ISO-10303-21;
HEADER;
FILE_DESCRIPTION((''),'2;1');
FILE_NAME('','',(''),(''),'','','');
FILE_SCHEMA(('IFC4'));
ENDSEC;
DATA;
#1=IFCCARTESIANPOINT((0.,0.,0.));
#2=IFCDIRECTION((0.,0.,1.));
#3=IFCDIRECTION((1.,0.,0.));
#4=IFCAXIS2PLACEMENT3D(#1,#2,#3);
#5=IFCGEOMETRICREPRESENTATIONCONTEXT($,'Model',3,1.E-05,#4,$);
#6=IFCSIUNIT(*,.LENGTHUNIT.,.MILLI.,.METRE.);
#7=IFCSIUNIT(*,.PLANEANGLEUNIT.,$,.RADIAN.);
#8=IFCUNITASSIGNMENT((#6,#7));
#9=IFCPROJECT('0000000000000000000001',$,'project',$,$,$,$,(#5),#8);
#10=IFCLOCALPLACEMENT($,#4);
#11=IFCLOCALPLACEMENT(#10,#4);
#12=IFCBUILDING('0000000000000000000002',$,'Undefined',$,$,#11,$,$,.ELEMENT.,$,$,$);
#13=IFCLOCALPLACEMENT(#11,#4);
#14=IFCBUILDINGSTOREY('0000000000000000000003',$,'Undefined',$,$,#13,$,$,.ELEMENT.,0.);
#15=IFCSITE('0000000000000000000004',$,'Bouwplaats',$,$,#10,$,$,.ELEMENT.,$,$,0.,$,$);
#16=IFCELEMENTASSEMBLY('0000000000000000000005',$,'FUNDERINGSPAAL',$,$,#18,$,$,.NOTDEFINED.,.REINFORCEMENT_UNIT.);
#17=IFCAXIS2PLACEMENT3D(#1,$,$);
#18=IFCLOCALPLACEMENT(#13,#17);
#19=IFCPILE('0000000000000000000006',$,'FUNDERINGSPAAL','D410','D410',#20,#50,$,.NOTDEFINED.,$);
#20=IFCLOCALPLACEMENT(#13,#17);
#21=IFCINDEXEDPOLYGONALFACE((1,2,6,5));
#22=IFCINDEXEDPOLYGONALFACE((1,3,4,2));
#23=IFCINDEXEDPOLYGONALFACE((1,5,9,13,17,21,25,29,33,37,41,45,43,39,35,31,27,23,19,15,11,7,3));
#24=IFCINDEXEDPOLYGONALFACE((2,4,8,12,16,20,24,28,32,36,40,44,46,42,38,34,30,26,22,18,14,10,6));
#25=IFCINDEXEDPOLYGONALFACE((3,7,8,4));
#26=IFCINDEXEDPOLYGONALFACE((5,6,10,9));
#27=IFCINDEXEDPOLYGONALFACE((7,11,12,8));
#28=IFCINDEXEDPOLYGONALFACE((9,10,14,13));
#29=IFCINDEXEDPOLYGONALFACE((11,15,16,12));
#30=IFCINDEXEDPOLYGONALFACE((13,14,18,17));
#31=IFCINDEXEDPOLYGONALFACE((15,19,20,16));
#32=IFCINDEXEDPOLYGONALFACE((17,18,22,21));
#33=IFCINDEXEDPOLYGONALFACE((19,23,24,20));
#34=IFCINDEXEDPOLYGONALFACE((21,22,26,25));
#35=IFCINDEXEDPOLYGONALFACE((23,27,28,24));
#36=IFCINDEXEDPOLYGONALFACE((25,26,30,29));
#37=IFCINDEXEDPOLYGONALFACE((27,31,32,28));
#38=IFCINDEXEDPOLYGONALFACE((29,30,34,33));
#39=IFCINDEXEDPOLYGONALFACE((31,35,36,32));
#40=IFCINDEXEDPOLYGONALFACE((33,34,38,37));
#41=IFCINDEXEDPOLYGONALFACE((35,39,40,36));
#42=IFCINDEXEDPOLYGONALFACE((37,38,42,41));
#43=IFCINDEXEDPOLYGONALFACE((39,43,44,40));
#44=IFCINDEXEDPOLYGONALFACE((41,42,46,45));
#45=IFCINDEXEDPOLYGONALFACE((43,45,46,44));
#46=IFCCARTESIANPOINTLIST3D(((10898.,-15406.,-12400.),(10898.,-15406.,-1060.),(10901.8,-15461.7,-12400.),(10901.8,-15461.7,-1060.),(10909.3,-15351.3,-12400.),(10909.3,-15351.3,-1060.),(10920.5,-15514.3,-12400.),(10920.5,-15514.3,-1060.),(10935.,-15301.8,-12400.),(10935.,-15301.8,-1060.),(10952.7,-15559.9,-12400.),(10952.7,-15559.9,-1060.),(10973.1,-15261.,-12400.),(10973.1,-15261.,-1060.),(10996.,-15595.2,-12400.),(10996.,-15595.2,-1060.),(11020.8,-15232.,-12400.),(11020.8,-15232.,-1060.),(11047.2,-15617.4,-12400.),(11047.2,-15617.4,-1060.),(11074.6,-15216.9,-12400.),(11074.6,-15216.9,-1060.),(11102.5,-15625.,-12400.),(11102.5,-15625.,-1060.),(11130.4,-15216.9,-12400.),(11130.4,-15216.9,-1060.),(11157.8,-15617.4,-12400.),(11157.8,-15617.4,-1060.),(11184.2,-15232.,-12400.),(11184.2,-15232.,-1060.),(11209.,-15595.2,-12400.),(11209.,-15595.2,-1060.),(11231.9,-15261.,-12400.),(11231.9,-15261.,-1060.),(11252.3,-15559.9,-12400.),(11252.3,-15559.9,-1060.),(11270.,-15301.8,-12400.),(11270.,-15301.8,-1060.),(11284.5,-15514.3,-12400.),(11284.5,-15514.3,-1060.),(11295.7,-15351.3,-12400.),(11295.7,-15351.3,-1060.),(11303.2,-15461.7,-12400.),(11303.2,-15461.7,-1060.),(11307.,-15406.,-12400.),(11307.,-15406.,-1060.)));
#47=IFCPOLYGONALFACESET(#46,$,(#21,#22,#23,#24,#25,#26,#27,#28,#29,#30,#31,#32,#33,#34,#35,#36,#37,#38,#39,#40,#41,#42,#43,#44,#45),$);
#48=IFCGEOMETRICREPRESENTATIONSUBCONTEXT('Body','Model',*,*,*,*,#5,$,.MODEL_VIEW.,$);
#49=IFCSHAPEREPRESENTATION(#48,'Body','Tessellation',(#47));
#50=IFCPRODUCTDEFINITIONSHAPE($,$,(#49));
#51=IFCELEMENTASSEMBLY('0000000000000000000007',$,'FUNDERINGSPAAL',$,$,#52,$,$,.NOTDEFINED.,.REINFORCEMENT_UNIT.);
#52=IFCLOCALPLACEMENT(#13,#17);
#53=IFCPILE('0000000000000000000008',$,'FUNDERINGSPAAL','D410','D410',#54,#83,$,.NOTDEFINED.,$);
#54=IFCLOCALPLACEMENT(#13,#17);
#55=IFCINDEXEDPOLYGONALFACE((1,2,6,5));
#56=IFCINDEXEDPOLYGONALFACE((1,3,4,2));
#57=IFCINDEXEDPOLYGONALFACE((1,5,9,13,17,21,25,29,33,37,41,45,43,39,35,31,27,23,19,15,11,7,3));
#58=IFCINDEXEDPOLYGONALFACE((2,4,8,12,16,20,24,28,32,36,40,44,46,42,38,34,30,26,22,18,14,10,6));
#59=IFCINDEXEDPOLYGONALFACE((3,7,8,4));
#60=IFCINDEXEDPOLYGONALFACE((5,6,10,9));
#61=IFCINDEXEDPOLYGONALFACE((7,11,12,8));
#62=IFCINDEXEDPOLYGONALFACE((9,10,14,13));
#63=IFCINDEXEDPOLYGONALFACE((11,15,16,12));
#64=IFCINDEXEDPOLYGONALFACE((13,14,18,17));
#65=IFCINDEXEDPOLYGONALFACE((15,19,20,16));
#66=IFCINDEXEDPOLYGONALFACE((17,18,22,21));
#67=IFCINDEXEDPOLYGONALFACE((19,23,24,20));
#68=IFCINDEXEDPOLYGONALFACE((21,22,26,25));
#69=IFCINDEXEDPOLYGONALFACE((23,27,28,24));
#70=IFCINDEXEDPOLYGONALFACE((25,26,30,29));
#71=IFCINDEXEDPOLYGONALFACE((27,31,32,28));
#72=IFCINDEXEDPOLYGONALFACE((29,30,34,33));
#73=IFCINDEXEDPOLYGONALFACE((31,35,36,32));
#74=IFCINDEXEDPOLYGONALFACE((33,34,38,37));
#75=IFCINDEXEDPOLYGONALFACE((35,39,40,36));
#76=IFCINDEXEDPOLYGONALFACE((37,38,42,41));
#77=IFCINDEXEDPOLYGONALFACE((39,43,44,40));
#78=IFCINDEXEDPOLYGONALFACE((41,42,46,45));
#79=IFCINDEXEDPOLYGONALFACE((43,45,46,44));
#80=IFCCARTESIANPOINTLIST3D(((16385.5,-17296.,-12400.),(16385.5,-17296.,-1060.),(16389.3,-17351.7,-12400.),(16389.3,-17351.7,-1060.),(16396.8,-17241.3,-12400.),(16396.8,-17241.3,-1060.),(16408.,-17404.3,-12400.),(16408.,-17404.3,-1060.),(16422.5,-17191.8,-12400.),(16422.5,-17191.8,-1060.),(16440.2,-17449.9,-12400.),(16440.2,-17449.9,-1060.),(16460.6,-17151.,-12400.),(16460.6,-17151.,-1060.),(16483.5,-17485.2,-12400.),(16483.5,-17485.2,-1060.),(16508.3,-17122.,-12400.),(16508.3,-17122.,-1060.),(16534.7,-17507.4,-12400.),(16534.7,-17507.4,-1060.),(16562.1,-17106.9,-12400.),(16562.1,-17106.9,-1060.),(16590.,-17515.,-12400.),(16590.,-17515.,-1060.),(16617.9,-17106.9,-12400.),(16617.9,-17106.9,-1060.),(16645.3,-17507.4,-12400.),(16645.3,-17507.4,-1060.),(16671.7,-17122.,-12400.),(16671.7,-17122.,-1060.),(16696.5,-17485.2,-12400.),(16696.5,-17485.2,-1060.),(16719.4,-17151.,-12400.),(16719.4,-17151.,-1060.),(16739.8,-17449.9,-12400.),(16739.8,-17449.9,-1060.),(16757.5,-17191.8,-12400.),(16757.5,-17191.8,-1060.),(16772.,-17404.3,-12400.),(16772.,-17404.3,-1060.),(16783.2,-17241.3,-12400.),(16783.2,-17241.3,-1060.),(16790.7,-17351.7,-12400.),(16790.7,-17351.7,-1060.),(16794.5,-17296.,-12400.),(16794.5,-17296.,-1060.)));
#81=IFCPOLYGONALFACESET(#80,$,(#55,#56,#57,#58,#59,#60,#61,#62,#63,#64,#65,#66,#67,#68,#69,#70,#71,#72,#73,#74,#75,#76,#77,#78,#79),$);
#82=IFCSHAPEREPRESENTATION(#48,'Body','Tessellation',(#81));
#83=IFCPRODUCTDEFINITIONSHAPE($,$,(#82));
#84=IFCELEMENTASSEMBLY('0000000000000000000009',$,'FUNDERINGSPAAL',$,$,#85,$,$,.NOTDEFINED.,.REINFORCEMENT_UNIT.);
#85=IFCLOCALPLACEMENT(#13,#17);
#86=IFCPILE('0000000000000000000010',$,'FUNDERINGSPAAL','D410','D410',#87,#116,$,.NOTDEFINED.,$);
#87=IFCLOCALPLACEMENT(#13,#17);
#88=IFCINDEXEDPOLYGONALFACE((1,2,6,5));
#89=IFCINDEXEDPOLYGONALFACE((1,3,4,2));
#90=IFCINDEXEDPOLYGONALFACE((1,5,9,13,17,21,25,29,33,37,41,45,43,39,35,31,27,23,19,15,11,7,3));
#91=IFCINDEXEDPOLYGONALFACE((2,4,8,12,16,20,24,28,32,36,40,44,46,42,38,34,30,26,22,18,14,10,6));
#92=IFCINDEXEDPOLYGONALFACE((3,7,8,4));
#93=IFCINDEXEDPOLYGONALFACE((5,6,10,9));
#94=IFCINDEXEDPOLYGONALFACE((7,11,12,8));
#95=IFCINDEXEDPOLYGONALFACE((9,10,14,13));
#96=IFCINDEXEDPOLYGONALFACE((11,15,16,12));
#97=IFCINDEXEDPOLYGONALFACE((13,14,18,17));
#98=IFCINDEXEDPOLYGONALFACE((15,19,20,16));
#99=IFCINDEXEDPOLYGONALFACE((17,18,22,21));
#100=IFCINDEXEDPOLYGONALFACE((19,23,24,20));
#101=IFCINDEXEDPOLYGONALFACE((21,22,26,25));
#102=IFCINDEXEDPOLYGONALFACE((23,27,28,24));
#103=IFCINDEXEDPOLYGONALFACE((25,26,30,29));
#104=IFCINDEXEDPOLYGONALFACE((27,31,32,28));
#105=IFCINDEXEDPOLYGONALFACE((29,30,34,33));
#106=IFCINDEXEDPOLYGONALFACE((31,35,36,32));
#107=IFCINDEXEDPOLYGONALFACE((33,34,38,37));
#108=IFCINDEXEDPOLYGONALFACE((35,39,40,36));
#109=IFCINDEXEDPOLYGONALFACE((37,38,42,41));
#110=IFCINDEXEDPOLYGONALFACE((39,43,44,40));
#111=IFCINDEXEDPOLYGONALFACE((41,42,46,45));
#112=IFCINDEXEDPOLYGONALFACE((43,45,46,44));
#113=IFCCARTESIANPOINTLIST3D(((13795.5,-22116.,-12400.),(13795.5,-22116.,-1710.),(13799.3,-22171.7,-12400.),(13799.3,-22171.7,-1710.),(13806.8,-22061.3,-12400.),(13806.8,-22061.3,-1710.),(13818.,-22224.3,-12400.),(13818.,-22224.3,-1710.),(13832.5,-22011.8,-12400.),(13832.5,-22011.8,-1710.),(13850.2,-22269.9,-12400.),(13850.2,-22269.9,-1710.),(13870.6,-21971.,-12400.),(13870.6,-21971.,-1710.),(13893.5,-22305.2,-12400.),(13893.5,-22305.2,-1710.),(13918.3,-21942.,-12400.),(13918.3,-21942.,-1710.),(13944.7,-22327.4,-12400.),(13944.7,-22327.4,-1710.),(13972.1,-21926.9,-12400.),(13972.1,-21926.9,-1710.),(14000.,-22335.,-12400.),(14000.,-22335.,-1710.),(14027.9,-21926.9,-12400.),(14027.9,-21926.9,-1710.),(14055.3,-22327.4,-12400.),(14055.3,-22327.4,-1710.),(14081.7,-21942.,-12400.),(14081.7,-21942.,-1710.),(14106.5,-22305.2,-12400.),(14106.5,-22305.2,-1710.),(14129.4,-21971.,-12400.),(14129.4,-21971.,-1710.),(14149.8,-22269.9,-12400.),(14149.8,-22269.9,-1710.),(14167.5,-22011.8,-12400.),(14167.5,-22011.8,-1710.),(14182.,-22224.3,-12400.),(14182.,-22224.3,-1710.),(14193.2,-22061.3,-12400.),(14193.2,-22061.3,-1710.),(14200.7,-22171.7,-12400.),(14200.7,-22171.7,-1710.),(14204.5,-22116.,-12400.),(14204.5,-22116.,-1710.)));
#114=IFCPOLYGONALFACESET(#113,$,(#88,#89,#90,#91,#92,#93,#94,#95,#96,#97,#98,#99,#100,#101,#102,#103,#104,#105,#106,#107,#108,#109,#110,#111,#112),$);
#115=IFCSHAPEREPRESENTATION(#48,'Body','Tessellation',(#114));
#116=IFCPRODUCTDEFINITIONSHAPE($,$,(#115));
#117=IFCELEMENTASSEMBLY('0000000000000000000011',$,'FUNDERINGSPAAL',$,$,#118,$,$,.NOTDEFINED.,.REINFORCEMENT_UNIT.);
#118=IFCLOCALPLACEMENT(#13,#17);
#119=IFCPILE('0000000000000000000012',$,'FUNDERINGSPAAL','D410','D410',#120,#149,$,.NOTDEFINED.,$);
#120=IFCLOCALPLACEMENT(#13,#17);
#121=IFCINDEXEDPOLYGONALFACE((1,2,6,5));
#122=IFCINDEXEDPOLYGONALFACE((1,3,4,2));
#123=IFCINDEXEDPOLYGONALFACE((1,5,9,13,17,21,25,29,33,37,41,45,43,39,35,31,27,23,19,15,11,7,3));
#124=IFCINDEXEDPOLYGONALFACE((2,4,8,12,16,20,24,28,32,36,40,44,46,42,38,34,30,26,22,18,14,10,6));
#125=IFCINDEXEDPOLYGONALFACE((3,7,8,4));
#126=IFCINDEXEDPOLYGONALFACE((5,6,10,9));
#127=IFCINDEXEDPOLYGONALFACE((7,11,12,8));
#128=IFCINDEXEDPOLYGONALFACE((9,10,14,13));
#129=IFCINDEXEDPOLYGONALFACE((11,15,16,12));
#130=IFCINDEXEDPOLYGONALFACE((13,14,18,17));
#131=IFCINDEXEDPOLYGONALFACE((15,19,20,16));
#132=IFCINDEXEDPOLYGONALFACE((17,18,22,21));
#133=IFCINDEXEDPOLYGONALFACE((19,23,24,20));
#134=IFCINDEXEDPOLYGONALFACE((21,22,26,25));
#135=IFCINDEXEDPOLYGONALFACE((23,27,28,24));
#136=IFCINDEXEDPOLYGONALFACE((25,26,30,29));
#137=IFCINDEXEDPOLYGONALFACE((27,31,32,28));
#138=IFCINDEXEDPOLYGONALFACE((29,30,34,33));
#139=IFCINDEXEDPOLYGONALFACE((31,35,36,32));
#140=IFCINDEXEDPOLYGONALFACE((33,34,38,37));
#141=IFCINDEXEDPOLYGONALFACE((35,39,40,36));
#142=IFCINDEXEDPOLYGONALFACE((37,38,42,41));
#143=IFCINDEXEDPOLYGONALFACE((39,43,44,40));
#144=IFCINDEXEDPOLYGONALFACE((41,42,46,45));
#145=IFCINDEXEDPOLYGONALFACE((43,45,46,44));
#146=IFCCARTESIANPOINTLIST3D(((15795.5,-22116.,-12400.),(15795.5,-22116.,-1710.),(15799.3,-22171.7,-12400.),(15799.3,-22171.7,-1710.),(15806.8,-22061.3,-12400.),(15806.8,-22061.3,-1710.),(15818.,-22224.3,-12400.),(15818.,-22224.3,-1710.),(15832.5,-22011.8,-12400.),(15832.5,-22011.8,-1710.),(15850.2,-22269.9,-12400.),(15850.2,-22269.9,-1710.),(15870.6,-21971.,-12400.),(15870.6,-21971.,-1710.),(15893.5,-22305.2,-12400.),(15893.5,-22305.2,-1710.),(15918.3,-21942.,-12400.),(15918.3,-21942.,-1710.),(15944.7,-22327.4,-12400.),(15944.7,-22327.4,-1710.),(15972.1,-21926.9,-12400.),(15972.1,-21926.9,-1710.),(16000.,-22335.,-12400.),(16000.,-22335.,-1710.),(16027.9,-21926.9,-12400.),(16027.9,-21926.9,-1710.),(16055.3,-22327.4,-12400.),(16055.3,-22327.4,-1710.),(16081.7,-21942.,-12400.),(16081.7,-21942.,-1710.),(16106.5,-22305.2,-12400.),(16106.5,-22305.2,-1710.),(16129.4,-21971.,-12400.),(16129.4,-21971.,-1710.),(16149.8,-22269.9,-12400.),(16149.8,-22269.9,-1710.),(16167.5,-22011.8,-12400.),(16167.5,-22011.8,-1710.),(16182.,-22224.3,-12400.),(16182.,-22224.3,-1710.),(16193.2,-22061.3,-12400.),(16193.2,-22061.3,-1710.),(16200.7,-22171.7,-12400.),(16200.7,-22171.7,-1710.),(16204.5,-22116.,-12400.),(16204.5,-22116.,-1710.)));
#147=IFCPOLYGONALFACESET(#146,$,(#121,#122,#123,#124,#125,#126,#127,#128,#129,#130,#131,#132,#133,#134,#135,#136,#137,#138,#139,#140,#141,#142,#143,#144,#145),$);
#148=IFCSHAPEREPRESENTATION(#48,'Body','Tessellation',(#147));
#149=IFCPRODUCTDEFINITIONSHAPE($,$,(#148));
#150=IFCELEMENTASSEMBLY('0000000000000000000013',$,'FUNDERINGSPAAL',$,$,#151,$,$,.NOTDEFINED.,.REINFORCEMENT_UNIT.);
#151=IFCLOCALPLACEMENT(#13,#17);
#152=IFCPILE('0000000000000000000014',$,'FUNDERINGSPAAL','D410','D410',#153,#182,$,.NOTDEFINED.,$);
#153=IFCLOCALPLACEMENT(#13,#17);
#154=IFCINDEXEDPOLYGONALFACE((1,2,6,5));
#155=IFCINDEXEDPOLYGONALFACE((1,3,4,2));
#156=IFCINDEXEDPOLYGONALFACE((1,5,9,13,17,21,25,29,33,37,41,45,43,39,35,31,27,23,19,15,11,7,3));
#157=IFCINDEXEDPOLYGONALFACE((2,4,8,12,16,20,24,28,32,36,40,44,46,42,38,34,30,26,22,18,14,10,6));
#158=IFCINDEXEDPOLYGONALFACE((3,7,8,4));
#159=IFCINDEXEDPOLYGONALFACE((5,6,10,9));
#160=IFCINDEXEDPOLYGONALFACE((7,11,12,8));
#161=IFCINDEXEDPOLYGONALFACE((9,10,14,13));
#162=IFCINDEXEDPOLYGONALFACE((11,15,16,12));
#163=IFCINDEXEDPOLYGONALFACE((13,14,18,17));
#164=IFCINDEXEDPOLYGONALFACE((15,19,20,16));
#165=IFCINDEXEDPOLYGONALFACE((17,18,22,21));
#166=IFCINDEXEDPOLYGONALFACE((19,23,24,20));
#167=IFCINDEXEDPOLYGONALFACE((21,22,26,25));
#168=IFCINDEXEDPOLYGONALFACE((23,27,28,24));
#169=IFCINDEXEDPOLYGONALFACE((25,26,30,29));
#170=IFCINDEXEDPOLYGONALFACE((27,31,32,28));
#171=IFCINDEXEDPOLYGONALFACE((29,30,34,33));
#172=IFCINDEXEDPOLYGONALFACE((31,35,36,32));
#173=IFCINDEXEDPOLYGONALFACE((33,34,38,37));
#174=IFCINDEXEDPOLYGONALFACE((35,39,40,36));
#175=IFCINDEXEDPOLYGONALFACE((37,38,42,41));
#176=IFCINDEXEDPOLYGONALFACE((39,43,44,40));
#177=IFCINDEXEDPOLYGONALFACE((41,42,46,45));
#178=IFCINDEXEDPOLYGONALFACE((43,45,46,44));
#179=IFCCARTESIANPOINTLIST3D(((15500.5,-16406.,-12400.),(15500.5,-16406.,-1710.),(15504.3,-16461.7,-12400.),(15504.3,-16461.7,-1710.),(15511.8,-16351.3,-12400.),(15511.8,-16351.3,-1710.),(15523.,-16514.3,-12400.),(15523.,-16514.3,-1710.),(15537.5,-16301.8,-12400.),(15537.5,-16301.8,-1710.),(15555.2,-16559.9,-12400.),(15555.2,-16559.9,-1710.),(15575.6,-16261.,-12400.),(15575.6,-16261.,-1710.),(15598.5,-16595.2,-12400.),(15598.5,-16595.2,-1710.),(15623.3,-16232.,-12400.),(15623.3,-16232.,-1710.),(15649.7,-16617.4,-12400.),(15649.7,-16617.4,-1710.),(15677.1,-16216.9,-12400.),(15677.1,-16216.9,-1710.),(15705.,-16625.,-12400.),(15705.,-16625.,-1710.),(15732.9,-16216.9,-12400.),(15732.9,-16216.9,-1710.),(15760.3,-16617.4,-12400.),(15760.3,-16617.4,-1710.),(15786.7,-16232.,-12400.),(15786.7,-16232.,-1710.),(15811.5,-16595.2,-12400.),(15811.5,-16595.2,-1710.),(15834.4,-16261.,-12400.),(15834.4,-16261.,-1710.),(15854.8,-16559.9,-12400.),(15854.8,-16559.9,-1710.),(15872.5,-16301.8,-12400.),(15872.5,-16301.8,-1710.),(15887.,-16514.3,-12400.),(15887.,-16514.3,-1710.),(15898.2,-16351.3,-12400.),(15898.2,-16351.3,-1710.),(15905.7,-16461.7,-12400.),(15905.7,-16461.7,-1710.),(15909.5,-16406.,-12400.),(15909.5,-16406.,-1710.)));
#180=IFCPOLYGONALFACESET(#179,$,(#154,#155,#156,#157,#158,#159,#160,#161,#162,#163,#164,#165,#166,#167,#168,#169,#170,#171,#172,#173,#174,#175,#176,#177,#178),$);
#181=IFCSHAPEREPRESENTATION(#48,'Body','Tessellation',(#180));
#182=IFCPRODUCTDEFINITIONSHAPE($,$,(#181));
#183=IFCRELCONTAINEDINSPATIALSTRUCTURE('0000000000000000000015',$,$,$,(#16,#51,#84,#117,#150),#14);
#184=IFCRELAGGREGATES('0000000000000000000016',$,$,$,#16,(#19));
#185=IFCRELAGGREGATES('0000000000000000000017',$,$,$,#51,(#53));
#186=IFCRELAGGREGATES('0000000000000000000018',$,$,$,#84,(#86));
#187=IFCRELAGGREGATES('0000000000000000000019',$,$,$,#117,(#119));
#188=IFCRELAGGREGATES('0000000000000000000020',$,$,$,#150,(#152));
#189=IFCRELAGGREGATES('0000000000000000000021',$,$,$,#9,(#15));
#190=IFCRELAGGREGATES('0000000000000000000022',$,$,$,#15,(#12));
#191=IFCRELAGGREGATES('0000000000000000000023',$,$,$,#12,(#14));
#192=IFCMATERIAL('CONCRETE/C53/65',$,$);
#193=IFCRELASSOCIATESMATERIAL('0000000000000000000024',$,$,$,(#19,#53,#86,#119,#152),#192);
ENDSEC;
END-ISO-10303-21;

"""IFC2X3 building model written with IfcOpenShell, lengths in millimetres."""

from ifc_helpers import new_model, si_unit, frame, origin_with_axes, origin_2d_with_axis, place, context, subcontext, project, spatial, circle, extrude, clip, halfspace, material, element, aggregate, save


model = new_model("IFC2X3")

# Units and contexts
model_context = context("Model", 3, precision=1e-05, world=origin_with_axes())
body_context = subcontext(model_context, "Body", "Model", "MODEL_VIEW")
ifc_project = project(units=[si_unit("LENGTHUNIT", "METRE", prefix="MILLI"), si_unit("PLANEANGLEUNIT", "RADIAN")], contexts=[model_context])

# Site, building, storey
site_placement = place(None, origin_with_axes())
site = spatial("IfcSite", under=ifc_project, at=site_placement, Name="Bouwplaats", CompositionType="ELEMENT", RefElevation=0.0)
building_placement = place(site_placement, origin_with_axes())
building = spatial("IfcBuilding", under=site, at=building_placement, Name="Undefined", CompositionType="ELEMENT")
storey_placement = place(building_placement, origin_with_axes())
storey = spatial("IfcBuildingStorey", under=building, at=storey_placement, Name="Undefined", CompositionType="ELEMENT", Elevation=0.0)

# Element assemblies, piles
assembly_1_placement = place(storey_placement, origin_with_axes())
assembly_1 = element("IfcElementAssembly", 1, at=assembly_1_placement, inside=storey, Name="FUNDERINGSPAAL", AssemblyPlace="NOTDEFINED", PredefinedType="REINFORCEMENT_UNIT")
ifc_material_1 = material(Name="CONCRETE/C53/65")
pile_1_placement = place(assembly_1_placement, frame((11102.5, -15420.0, -1060.0), z_axis=(1.0, 0.0, 0.0), x_axis=(0.0, 0.0, -1.0)))
pile_1 = element("IfcPile", 2, at=pile_1_placement, material=ifc_material_1, Name="FUNDERINGSPAAL", Description="D410", ObjectType="D410", PredefinedType="NOTDEFINED", context=body_context, shape_type="Clipping", body=[
    clip(extrude(circle(Radius=205.0, at=origin_2d_with_axis()), frame((11340.0, 0.0, 0.0), z_axis=(-1.0, 0.0, 0.0), x_axis=(0.0, -1.0, 0.0)), (0.0, 0.0, 1.0), 11340.0), halfspace(frame((0.0, 205.0, -205.0), z_axis=(-1.0, 0.0, 0.0), x_axis=(0.0, 0.0, 1.0)), False)),
])
aggregate(assembly_1, [pile_1])
assembly_2_placement = place(storey_placement, origin_with_axes())
assembly_2 = element("IfcElementAssembly", 3, at=assembly_2_placement, inside=storey, Name="FUNDERINGSPAAL", AssemblyPlace="NOTDEFINED", PredefinedType="REINFORCEMENT_UNIT")
pile_2_placement = place(assembly_2_placement, frame((16590.0, -17310.0, -1060.0), z_axis=(1.0, 0.0, 0.0), x_axis=(0.0, 0.0, -1.0)))
pile_2 = element("IfcPile", 4, at=pile_2_placement, material=ifc_material_1, Name="FUNDERINGSPAAL", Description="D410", ObjectType="D410", PredefinedType="NOTDEFINED", context=body_context, shape_type="Clipping", body=[
    clip(extrude(circle(Radius=205.0, at=origin_2d_with_axis()), frame((11340.0, 0.0, 0.0), z_axis=(-1.0, 0.0, 0.0), x_axis=(0.0, -1.0, 0.0)), (0.0, 0.0, 1.0), 11340.0), halfspace(frame((0.0, 205.0, -205.0), z_axis=(-1.0, 0.0, 0.0), x_axis=(0.0, 0.0, 1.0)), False)),
])
aggregate(assembly_2, [pile_2])
assembly_3_placement = place(storey_placement, origin_with_axes())
assembly_3 = element("IfcElementAssembly", 5, at=assembly_3_placement, inside=storey, Name="FUNDERINGSPAAL", AssemblyPlace="NOTDEFINED", PredefinedType="REINFORCEMENT_UNIT")
pile_3_placement = place(assembly_3_placement, frame((14000.0, -22130.0, -1710.0), z_axis=(1.0, 0.0, 0.0), x_axis=(0.0, 0.0, -1.0)))
pile_3 = element("IfcPile", 6, at=pile_3_placement, material=ifc_material_1, Name="FUNDERINGSPAAL", Description="D410", ObjectType="D410", PredefinedType="NOTDEFINED", context=body_context, shape_type="Clipping", body=[
    clip(extrude(circle(Radius=205.0, at=origin_2d_with_axis()), frame((10690.0, 0.0, 0.0), z_axis=(-1.0, 0.0, 0.0), x_axis=(0.0, -1.0, 0.0)), (0.0, 0.0, 1.0), 10690.0), halfspace(frame((0.0, 205.0, -205.0), z_axis=(-1.0, 0.0, 0.0), x_axis=(0.0, 0.0, 1.0)), False)),
])
aggregate(assembly_3, [pile_3])
assembly_4_placement = place(storey_placement, origin_with_axes())
assembly_4 = element("IfcElementAssembly", 7, at=assembly_4_placement, inside=storey, Name="FUNDERINGSPAAL", AssemblyPlace="NOTDEFINED", PredefinedType="REINFORCEMENT_UNIT")
pile_4_placement = place(assembly_4_placement, frame((16000.0, -22130.0, -1710.0), z_axis=(1.0, 0.0, 0.0), x_axis=(0.0, 0.0, -1.0)))
pile_4 = element("IfcPile", 8, at=pile_4_placement, material=ifc_material_1, Name="FUNDERINGSPAAL", Description="D410", ObjectType="D410", PredefinedType="NOTDEFINED", context=body_context, shape_type="Clipping", body=[
    clip(extrude(circle(Radius=205.0, at=origin_2d_with_axis()), frame((10690.0, 0.0, 0.0), z_axis=(-1.0, 0.0, 0.0), x_axis=(0.0, -1.0, 0.0)), (0.0, 0.0, 1.0), 10690.0), halfspace(frame((0.0, 205.0, -205.0), z_axis=(-1.0, 0.0, 0.0), x_axis=(0.0, 0.0, 1.0)), False)),
])
aggregate(assembly_4, [pile_4])
assembly_5_placement = place(storey_placement, origin_with_axes())
assembly_5 = element("IfcElementAssembly", 9, at=assembly_5_placement, inside=storey, Name="FUNDERINGSPAAL", AssemblyPlace="NOTDEFINED", PredefinedType="REINFORCEMENT_UNIT")
pile_5_placement = place(assembly_5_placement, frame((15705.0, -16420.0, -1710.0), z_axis=(1.0, 0.0, 0.0), x_axis=(0.0, 0.0, -1.0)))
pile_5 = element("IfcPile", 10, at=pile_5_placement, material=ifc_material_1, Name="FUNDERINGSPAAL", Description="D410", ObjectType="D410", PredefinedType="NOTDEFINED", context=body_context, shape_type="Clipping", body=[
    clip(extrude(circle(Radius=205.0, at=origin_2d_with_axis()), frame((10690.0, 0.0, 0.0), z_axis=(-1.0, 0.0, 0.0), x_axis=(0.0, -1.0, 0.0)), (0.0, 0.0, 1.0), 10690.0), halfspace(frame((0.0, 205.0, -205.0), z_axis=(-1.0, 0.0, 0.0), x_axis=(0.0, 0.0, 1.0)), False)),
])
aggregate(assembly_5, [pile_5])

save(model, "model.ifc")
